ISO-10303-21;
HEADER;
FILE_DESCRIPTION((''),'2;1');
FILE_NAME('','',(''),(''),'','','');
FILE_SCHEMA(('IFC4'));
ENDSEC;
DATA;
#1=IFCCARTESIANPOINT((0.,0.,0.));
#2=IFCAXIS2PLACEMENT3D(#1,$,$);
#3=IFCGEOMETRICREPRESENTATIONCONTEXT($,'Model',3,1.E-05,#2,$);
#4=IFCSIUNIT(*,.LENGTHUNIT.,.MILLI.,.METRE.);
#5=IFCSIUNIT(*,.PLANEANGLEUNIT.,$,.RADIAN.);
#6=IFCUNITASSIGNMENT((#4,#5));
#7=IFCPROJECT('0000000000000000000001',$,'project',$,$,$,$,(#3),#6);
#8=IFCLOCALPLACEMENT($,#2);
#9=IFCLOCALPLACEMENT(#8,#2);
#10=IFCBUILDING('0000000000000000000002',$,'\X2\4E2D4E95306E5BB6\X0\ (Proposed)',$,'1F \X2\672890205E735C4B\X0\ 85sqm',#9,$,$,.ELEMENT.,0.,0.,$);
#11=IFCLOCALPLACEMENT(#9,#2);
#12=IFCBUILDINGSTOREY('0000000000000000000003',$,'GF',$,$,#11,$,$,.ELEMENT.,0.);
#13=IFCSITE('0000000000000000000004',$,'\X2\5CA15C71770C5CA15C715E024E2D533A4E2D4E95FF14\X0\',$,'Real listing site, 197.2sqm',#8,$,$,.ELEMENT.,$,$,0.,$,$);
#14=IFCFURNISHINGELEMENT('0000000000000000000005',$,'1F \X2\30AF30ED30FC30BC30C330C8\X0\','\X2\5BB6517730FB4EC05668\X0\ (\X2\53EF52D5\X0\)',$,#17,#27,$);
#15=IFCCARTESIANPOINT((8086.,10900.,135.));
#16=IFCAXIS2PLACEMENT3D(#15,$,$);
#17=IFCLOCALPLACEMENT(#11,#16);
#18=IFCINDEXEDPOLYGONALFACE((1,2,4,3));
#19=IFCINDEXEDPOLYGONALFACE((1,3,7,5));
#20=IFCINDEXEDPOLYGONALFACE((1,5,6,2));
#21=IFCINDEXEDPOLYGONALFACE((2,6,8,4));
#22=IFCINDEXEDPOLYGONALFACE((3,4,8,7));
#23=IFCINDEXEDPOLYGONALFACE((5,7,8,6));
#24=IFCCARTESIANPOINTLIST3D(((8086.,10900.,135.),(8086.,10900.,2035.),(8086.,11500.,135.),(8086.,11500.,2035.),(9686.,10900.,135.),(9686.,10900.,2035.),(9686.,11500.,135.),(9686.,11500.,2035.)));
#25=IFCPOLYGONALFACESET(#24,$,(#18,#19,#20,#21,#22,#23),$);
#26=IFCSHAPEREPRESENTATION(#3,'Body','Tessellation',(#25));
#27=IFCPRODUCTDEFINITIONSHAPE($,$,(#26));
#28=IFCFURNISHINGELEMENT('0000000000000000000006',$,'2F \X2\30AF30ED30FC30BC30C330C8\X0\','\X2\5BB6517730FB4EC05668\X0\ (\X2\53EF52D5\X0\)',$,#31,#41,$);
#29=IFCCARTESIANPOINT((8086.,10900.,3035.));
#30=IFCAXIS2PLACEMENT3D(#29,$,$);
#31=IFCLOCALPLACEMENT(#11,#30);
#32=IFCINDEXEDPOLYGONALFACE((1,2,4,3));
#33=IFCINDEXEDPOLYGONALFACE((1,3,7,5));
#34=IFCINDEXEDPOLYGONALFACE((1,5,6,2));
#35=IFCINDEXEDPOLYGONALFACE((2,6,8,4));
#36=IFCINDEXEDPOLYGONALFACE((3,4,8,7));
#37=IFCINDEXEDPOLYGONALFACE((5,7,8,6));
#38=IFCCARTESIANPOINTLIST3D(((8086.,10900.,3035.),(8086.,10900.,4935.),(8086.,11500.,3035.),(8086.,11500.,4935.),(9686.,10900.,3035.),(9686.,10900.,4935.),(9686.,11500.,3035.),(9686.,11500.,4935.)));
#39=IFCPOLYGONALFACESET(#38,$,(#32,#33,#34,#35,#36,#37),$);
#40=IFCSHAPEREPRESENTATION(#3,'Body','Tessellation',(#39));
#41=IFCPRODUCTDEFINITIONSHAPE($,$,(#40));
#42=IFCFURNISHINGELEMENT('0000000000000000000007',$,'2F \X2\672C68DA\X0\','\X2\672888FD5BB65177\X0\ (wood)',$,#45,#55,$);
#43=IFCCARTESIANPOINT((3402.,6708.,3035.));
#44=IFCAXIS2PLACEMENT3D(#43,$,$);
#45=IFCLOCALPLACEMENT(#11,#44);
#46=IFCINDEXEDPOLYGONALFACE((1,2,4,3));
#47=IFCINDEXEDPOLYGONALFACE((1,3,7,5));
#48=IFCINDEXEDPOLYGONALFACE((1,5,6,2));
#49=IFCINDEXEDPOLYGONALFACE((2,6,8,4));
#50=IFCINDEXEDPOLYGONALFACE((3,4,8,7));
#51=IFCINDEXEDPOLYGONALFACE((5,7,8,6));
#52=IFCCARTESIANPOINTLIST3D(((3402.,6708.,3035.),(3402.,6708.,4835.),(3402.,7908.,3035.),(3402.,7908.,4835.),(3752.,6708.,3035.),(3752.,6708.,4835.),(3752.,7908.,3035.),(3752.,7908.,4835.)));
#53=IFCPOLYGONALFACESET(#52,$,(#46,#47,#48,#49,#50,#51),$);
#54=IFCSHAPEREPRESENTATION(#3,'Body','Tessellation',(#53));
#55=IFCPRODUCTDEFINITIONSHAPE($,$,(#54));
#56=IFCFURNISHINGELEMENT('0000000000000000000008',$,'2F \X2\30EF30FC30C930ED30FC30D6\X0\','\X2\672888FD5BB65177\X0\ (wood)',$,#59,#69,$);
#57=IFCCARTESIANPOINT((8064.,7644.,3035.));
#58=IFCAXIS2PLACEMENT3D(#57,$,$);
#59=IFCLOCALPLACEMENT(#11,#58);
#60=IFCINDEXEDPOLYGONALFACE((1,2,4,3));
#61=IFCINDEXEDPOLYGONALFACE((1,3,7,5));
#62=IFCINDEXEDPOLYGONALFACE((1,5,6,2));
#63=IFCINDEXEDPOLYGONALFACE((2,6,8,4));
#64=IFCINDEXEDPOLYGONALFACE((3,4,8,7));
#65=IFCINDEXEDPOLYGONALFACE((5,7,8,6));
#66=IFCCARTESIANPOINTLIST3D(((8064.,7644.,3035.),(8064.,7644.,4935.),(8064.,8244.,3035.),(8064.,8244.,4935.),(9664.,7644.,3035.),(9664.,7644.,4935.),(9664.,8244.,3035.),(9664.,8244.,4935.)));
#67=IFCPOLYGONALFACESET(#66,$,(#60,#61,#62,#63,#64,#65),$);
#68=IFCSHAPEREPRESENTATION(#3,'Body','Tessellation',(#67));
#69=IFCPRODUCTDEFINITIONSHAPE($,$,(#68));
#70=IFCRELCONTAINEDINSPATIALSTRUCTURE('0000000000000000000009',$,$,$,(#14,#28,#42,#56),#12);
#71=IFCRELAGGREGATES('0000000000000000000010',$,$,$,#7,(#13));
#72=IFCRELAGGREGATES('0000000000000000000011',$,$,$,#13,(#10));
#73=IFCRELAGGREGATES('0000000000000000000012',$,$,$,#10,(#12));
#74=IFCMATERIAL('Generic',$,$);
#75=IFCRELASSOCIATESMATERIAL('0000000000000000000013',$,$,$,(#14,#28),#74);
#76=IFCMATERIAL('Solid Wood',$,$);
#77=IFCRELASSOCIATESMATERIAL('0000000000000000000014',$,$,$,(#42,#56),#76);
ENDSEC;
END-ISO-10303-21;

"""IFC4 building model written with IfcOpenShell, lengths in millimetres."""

from ifc_helpers import new_model, si_unit, frame, frame_2d, origin, place, context, project, spatial, rectangle, extrude, material, element, save


model = new_model("IFC4")

# Units and contexts
model_context = context("Model", 3, precision=1e-05, world=origin())
ifc_project = project(units=[si_unit("LENGTHUNIT", "METRE", prefix="MILLI"), si_unit("PLANEANGLEUNIT", "RADIAN")], contexts=[model_context])

# Site, building, storey
site_placement = place(None, origin())
site = spatial("IfcSite", under=ifc_project, at=site_placement, Name="岡山県岡山市中区中井４", ObjectType="Real listing site, 197.2sqm", CompositionType="ELEMENT", RefElevation=0.0)
building_placement = place(site_placement, origin())
building = spatial("IfcBuilding", under=site, at=building_placement, Name="中井の家 (Proposed)", ObjectType="1F 木造平屋 85sqm", CompositionType="ELEMENT", ElevationOfRefHeight=0.0, ElevationOfTerrain=0.0)
storey_placement = place(building_placement, origin())
storey = spatial("IfcBuildingStorey", under=building, at=storey_placement, Name="GF", CompositionType="ELEMENT", Elevation=0.0)

# Shared definitions
ifc_material_1 = material(Name="Solid Wood")

# Shared definitions
ifc_material_2 = material(Name="Generic")

# Furnishing elements
furnishing_1_placement = place(storey_placement, frame((8086.0, 10900.0, 135.0)))
element("IfcFurnishingElement", 1, at=furnishing_1_placement, inside=storey, material=ifc_material_2, Name="1F クローゼット", Description="家具・什器 (可動)", context=model_context, shape_type="SweptSolid", body=[
    extrude(rectangle(XDim=1600.0, YDim=600.0, at=frame_2d((800.0, 300.0))), frame((8086.0, 10900.0, 135.0)), (0.0, 0.0, 1.0), 1900.0),
])
furnishing_2_placement = place(storey_placement, frame((8086.0, 10900.0, 3035.0)))
element("IfcFurnishingElement", 2, at=furnishing_2_placement, inside=storey, material=ifc_material_2, Name="2F クローゼット", Description="家具・什器 (可動)", context=model_context, shape_type="SweptSolid", body=[
    extrude(rectangle(XDim=1600.0, YDim=600.0, at=frame_2d((800.0, 300.0))), frame((8086.0, 10900.0, 3035.0)), (0.0, 0.0, 1.0), 1900.0),
])
furnishing_3_placement = place(storey_placement, frame((3402.0, 6708.0, 3035.0)))
element("IfcFurnishingElement", 3, at=furnishing_3_placement, inside=storey, material=ifc_material_1, Name="2F 本棚", Description="木製家具 (wood)", context=model_context, shape_type="SweptSolid", body=[
    extrude(rectangle(XDim=350.0, YDim=1200.0, at=frame_2d((175.0, 600.0))), frame((3402.0, 6708.0, 3035.0)), (0.0, 0.0, 1.0), 1800.0),
])
furnishing_4_placement = place(storey_placement, frame((8064.0, 7644.0, 3035.0)))
element("IfcFurnishingElement", 4, at=furnishing_4_placement, inside=storey, material=ifc_material_1, Name="2F ワードローブ", Description="木製家具 (wood)", context=model_context, shape_type="SweptSolid", body=[
    extrude(rectangle(XDim=1600.0, YDim=600.0, at=frame_2d((800.0, 300.0))), frame((8064.0, 7644.0, 3035.0)), (0.0, 0.0, 1.0), 1900.0),
])

save(model, "model.ifc")
